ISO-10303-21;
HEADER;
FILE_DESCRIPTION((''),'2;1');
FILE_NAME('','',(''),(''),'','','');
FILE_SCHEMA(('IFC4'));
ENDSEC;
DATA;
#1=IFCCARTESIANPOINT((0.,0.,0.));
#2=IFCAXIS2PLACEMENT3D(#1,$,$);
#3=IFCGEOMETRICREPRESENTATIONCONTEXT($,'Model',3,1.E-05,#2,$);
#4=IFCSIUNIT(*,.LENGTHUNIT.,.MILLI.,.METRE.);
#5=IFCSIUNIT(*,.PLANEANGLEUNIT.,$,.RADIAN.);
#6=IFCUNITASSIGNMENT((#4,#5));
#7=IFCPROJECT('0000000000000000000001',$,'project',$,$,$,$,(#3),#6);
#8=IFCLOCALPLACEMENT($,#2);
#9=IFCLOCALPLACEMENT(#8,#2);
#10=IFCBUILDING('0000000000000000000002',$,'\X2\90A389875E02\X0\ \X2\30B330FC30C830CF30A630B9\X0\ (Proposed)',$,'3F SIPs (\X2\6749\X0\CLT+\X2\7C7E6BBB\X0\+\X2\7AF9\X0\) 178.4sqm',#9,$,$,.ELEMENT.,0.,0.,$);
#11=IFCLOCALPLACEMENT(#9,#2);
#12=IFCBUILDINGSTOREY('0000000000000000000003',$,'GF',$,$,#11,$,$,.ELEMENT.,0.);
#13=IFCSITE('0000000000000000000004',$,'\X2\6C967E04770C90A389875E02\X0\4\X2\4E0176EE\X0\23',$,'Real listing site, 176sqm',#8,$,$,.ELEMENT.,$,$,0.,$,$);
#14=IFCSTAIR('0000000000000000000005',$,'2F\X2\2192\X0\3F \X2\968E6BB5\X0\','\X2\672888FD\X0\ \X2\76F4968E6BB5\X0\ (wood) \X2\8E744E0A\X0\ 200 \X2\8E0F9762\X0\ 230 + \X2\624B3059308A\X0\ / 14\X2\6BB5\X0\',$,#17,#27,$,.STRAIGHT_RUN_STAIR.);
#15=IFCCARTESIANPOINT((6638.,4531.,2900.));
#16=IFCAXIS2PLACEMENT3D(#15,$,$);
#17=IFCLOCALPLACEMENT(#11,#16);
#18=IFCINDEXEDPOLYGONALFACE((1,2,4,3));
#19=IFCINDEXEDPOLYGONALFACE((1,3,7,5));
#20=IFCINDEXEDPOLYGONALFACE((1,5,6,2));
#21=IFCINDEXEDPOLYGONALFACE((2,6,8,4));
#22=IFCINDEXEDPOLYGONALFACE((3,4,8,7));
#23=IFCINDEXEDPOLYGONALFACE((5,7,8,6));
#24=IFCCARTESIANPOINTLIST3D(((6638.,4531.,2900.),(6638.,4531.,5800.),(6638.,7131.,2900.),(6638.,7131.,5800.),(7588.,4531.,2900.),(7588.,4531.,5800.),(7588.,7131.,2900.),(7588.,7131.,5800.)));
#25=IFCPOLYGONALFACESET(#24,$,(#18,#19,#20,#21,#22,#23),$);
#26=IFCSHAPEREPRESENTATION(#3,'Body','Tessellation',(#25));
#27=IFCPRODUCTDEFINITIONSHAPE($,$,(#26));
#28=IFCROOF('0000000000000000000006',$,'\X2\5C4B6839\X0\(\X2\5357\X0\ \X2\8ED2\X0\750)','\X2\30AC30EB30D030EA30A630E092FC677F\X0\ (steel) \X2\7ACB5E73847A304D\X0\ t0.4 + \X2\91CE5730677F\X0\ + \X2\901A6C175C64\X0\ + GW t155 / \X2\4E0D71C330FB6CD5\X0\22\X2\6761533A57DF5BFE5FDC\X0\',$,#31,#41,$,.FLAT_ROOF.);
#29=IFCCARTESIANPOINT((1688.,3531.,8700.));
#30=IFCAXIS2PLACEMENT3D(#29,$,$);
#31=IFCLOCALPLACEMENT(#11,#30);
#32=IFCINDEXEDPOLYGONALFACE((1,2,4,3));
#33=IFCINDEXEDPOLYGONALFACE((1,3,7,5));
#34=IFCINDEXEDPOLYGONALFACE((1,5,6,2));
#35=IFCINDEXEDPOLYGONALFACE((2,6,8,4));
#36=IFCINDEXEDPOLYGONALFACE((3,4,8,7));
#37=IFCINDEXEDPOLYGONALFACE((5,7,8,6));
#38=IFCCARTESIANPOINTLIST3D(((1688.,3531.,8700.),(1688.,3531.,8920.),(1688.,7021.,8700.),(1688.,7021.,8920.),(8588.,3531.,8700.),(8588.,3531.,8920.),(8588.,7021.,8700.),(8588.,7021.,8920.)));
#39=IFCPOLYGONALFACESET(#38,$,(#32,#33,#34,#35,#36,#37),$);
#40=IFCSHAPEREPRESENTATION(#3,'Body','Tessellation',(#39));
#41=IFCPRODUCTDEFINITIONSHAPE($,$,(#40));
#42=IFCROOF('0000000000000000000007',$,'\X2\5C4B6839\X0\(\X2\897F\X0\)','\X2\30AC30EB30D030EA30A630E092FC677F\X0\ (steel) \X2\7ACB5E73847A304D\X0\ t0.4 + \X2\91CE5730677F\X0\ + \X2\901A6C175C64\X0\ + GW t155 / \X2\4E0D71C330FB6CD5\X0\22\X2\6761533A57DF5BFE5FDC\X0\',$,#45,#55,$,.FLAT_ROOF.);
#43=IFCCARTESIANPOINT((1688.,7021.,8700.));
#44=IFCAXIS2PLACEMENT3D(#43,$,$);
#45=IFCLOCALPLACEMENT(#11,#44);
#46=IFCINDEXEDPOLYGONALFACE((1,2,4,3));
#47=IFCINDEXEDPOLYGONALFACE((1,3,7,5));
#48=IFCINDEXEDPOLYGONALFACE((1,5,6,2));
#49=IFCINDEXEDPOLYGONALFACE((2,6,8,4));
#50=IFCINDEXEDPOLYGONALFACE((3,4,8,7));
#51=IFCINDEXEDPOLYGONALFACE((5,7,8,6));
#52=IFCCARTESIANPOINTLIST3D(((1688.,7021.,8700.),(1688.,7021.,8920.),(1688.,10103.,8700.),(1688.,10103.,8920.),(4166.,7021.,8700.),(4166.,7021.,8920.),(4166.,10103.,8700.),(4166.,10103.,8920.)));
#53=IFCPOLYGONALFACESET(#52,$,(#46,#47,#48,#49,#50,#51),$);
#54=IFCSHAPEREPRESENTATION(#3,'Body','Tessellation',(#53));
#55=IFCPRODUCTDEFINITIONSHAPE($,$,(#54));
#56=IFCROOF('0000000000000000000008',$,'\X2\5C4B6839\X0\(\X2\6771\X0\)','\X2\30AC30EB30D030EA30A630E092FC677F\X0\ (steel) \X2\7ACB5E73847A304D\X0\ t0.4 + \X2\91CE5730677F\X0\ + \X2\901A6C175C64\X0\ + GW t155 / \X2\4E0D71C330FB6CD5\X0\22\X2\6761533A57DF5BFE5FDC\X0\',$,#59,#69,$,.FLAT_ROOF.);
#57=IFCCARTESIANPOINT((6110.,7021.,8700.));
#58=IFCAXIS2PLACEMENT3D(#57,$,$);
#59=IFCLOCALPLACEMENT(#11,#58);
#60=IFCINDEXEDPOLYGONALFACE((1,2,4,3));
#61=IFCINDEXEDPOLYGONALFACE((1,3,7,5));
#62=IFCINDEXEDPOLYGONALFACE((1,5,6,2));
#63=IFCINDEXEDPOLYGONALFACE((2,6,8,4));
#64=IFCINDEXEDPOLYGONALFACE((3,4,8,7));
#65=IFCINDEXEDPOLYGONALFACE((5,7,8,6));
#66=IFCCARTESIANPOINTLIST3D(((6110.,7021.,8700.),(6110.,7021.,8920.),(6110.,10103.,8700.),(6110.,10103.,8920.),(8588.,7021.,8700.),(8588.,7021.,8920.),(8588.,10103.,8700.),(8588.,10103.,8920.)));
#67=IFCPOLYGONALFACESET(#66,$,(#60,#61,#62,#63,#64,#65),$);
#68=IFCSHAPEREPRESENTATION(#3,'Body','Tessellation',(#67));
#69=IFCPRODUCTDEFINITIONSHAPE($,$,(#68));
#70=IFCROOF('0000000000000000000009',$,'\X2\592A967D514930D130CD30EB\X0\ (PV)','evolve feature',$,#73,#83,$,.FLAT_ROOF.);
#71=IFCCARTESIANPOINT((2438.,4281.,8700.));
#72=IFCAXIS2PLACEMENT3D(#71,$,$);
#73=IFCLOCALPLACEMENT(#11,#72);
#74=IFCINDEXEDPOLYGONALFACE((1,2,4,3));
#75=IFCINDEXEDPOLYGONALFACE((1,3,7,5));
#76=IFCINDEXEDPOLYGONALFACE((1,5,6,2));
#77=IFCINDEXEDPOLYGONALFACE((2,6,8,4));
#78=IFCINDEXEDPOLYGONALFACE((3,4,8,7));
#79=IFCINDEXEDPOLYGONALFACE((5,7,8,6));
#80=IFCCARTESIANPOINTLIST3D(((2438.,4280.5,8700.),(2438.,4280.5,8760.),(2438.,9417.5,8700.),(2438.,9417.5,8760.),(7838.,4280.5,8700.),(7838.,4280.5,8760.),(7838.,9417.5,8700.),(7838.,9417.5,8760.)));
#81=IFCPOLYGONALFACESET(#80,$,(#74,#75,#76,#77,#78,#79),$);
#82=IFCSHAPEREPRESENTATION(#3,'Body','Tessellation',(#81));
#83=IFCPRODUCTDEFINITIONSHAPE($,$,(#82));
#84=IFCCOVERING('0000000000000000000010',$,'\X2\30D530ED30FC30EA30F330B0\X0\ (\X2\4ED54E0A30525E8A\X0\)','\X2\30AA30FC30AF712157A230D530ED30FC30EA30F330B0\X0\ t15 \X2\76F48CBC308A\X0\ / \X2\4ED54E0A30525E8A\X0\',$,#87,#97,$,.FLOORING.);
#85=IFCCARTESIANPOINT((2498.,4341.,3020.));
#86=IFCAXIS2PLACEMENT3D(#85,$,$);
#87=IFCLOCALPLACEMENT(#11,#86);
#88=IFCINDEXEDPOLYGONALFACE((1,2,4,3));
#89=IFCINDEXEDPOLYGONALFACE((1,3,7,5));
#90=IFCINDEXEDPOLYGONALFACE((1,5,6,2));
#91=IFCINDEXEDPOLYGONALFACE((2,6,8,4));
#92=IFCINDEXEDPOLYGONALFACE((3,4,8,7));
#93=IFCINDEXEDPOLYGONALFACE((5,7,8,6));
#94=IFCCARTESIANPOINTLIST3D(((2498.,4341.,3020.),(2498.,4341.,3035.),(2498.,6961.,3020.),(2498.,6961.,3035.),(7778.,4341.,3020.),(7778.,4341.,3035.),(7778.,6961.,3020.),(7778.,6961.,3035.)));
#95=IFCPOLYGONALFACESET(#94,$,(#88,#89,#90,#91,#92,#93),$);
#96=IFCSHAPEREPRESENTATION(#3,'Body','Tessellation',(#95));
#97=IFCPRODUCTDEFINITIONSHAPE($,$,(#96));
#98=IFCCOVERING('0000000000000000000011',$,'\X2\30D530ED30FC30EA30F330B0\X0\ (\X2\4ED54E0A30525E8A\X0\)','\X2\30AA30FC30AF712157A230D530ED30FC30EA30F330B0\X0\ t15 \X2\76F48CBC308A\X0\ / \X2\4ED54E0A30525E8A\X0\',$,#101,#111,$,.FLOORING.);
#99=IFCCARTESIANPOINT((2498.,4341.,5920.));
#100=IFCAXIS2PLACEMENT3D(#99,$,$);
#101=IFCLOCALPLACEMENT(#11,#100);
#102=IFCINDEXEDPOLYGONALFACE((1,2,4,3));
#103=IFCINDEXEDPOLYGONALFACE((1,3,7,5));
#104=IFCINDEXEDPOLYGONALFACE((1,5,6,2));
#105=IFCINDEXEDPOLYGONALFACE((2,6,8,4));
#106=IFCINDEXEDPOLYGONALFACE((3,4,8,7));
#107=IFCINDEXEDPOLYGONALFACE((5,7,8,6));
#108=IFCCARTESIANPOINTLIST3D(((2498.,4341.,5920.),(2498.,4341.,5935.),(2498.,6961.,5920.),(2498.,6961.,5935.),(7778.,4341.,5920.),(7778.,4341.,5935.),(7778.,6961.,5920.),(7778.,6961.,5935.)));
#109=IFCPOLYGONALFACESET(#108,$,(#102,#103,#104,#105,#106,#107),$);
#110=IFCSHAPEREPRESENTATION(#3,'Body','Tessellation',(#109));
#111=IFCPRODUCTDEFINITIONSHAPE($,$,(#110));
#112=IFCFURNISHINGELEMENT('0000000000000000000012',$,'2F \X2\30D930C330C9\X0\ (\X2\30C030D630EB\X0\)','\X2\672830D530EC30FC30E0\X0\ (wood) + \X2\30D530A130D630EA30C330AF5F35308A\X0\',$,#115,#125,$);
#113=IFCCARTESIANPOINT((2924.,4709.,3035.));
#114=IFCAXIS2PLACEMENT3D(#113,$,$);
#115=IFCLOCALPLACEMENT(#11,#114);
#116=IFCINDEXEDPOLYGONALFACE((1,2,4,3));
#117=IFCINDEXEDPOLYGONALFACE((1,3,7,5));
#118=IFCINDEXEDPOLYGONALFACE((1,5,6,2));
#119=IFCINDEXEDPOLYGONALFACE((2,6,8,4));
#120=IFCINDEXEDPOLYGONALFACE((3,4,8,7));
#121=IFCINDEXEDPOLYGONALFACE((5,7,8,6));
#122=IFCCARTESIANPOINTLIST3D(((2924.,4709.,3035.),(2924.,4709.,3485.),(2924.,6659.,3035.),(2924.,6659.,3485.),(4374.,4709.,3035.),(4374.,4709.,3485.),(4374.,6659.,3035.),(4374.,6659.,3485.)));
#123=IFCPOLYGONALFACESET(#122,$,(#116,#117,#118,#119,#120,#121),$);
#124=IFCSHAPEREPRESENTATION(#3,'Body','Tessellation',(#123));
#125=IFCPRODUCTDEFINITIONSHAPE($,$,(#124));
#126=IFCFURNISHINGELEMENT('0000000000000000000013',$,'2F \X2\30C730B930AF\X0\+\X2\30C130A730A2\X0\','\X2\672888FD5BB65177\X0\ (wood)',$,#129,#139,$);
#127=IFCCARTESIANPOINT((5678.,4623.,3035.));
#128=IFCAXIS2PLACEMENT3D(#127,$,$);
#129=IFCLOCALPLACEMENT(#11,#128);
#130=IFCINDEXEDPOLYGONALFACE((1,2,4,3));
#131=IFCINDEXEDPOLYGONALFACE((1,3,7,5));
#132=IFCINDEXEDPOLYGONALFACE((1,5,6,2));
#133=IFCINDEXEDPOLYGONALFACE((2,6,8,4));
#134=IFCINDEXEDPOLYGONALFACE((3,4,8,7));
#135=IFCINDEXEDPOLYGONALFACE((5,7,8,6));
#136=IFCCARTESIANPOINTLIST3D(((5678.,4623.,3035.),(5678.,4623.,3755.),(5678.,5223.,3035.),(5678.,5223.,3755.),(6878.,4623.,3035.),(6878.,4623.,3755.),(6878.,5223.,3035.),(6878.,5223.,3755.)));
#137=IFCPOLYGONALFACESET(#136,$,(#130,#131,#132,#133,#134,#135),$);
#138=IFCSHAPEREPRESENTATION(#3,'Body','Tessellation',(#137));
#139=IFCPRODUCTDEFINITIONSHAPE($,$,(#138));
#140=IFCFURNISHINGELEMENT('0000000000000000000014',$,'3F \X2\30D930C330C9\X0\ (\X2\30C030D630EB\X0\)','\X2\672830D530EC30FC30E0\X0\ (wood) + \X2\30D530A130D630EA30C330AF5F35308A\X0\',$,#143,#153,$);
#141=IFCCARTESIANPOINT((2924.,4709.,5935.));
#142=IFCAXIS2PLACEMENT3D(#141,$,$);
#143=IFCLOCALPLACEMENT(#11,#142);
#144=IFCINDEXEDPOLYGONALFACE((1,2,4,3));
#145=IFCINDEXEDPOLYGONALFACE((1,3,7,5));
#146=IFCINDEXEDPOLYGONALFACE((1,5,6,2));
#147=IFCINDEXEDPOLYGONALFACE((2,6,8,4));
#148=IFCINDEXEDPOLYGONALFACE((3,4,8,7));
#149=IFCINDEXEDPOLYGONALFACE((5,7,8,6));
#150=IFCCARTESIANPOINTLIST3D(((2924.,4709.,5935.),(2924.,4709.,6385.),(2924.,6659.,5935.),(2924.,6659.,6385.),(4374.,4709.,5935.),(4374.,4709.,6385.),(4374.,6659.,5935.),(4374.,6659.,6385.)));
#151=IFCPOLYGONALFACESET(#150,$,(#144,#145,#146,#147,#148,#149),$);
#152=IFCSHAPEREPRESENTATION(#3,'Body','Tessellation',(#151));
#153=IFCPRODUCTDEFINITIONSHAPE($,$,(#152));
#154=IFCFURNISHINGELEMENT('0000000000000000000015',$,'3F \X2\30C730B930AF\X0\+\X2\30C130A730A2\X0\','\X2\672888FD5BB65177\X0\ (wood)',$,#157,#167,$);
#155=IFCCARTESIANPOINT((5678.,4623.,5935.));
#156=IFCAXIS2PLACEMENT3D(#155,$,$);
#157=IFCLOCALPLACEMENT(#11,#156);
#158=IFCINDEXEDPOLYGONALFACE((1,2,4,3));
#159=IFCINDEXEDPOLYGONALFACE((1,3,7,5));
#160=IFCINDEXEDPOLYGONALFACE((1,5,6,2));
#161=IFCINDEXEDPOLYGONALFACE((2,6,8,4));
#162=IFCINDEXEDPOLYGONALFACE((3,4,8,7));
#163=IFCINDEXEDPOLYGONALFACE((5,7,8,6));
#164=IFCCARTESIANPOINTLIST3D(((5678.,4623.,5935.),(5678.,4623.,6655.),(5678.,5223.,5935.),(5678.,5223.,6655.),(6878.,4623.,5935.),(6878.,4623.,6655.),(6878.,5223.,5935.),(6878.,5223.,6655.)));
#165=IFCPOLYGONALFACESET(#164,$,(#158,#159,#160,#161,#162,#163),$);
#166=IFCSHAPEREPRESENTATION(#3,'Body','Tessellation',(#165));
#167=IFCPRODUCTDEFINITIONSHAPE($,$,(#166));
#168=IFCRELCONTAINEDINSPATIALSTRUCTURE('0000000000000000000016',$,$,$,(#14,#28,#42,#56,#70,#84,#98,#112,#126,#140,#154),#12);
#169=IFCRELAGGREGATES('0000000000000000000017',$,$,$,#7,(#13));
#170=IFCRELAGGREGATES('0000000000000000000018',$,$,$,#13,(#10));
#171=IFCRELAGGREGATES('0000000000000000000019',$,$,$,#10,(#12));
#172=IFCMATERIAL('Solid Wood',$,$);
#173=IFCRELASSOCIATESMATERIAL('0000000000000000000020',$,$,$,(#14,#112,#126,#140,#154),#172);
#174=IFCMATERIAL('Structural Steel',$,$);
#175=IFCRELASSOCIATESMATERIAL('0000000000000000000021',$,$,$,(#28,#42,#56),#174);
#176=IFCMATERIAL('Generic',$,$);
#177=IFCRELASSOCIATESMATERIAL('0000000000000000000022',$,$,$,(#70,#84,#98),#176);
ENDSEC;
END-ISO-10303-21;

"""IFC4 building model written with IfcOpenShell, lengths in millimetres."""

from ifc_helpers import new_model, si_unit, frame, frame_2d, origin, place, context, project, spatial, rectangle, extrude, material, element, save


model = new_model("IFC4")

# Units and contexts
model_context = context("Model", 3, precision=1e-05, world=origin())
ifc_project = project(units=[si_unit("LENGTHUNIT", "METRE", prefix="MILLI"), si_unit("PLANEANGLEUNIT", "RADIAN")], contexts=[model_context])

# Site, building, storey
site_placement = place(None, origin())
site = spatial("IfcSite", under=ifc_project, at=site_placement, Name="沖縄県那覇市4丁目23", ObjectType="Real listing site, 176sqm", CompositionType="ELEMENT", RefElevation=0.0)
building_placement = place(site_placement, origin())
building = spatial("IfcBuilding", under=site, at=building_placement, Name="那覇市 コートハウス (Proposed)", ObjectType="3F SIPs (杉CLT+籾殻+竹) 178.4sqm", CompositionType="ELEMENT", ElevationOfRefHeight=0.0, ElevationOfTerrain=0.0)
storey_placement = place(building_placement, origin())
storey = spatial("IfcBuildingStorey", under=building, at=storey_placement, Name="GF", CompositionType="ELEMENT", Elevation=0.0)

# Shared definitions
ifc_material_1 = material(Name="Solid Wood")

# Stair
stair_placement = place(storey_placement, frame((6638.0, 4531.0, 2900.0)))
element("IfcStair", 1, at=stair_placement, inside=storey, material=ifc_material_1, Name="2F→3F 階段", Description="木製 直階段 (wood) 蹴上 200 踏面 230 + 手すり / 14段", PredefinedType="STRAIGHT_RUN_STAIR", context=model_context, shape_type="SweptSolid", body=[
    extrude(rectangle(XDim=950.0, YDim=2600.0, at=frame_2d((475.0, 1300.0))), frame((6638.0, 4531.0, 2900.0)), (0.0, 0.0, 1.0), 2900.0),
])

# Roofs
ifc_material_2 = material(Name="Structural Steel")
roof_1_placement = place(storey_placement, frame((1688.0, 3531.0, 8700.0)))
element("IfcRoof", 2, at=roof_1_placement, inside=storey, material=ifc_material_2, Name="屋根(南 軒750)", Description="ガルバリウム鋼板 (steel) 立平葺き t0.4 + 野地板 + 通気層 + GW t155 / 不燃・法22条区域対応", PredefinedType="FLAT_ROOF", context=model_context, shape_type="SweptSolid", body=[
    extrude(rectangle(XDim=6900.0, YDim=3490.0, at=frame_2d((3450.0, 1745.0))), frame((1688.0, 3531.0, 8700.0)), (0.0, 0.0, 1.0), 220.0),
])
roof_2_placement = place(storey_placement, frame((1688.0, 7021.0, 8700.0)))
element("IfcRoof", 3, at=roof_2_placement, inside=storey, material=ifc_material_2, Name="屋根(西)", Description="ガルバリウム鋼板 (steel) 立平葺き t0.4 + 野地板 + 通気層 + GW t155 / 不燃・法22条区域対応", PredefinedType="FLAT_ROOF", context=model_context, shape_type="SweptSolid", body=[
    extrude(rectangle(XDim=2478.0, YDim=3082.0, at=frame_2d((1239.0, 1541.0))), frame((1688.0, 7021.0, 8700.0)), (0.0, 0.0, 1.0), 220.0),
])
roof_3_placement = place(storey_placement, frame((6110.0, 7021.0, 8700.0)))
element("IfcRoof", 4, at=roof_3_placement, inside=storey, material=ifc_material_2, Name="屋根(東)", Description="ガルバリウム鋼板 (steel) 立平葺き t0.4 + 野地板 + 通気層 + GW t155 / 不燃・法22条区域対応", PredefinedType="FLAT_ROOF", context=model_context, shape_type="SweptSolid", body=[
    extrude(rectangle(XDim=2478.0, YDim=3082.0, at=frame_2d((1239.0, 1541.0))), frame((6110.0, 7021.0, 8700.0)), (0.0, 0.0, 1.0), 220.0),
])
ifc_material_3 = material(Name="Generic")
roof_4_placement = place(storey_placement, frame((2438.0, 4281.0, 8700.0)))
element("IfcRoof", 5, at=roof_4_placement, inside=storey, material=ifc_material_3, Name="太陽光パネル (PV)", Description="evolve feature", PredefinedType="FLAT_ROOF", context=model_context, shape_type="SweptSolid", body=[
    extrude(rectangle(XDim=5400.0, YDim=5137.0, at=frame_2d((2700.0, 2568.0))), frame((2438.0, 4281.0, 8700.0)), (0.0, 0.0, 1.0), 60.0),
])

# Coverings
covering_1_placement = place(storey_placement, frame((2498.0, 4341.0, 3020.0)))
element("IfcCovering", 6, at=covering_1_placement, inside=storey, material=ifc_material_3, Name="フローリング (仕上げ床)", Description="オーク無垢フローリング t15 直貼り / 仕上げ床", PredefinedType="FLOORING", context=model_context, shape_type="SweptSolid", body=[
    extrude(rectangle(XDim=5280.0, YDim=2620.0, at=frame_2d((2640.0, 1310.0))), frame((2498.0, 4341.0, 3020.0)), (0.0, 0.0, 1.0), 15.0),
])
covering_2_placement = place(storey_placement, frame((2498.0, 4341.0, 5920.0)))
element("IfcCovering", 7, at=covering_2_placement, inside=storey, material=ifc_material_3, Name="フローリング (仕上げ床)", Description="オーク無垢フローリング t15 直貼り / 仕上げ床", PredefinedType="FLOORING", context=model_context, shape_type="SweptSolid", body=[
    extrude(rectangle(XDim=5280.0, YDim=2620.0, at=frame_2d((2640.0, 1310.0))), frame((2498.0, 4341.0, 5920.0)), (0.0, 0.0, 1.0), 15.0),
])

# Furnishing elements
furnishing_1_placement = place(storey_placement, frame((2924.0, 4709.0, 3035.0)))
element("IfcFurnishingElement", 8, at=furnishing_1_placement, inside=storey, material=ifc_material_1, Name="2F ベッド (ダブル)", Description="木フレーム (wood) + ファブリック張り", context=model_context, shape_type="SweptSolid", body=[
    extrude(rectangle(XDim=1450.0, YDim=1950.0, at=frame_2d((725.0, 975.0))), frame((2924.0, 4709.0, 3035.0)), (0.0, 0.0, 1.0), 450.0),
])
furnishing_2_placement = place(storey_placement, frame((5678.0, 4623.0, 3035.0)))
element("IfcFurnishingElement", 9, at=furnishing_2_placement, inside=storey, material=ifc_material_1, Name="2F デスク+チェア", Description="木製家具 (wood)", context=model_context, shape_type="SweptSolid", body=[
    extrude(rectangle(XDim=1200.0, YDim=600.0, at=frame_2d((600.0, 300.0))), frame((5678.0, 4623.0, 3035.0)), (0.0, 0.0, 1.0), 720.0),
])
furnishing_3_placement = place(storey_placement, frame((2924.0, 4709.0, 5935.0)))
element("IfcFurnishingElement", 10, at=furnishing_3_placement, inside=storey, material=ifc_material_1, Name="3F ベッド (ダブル)", Description="木フレーム (wood) + ファブリック張り", context=model_context, shape_type="SweptSolid", body=[
    extrude(rectangle(XDim=1450.0, YDim=1950.0, at=frame_2d((725.0, 975.0))), frame((2924.0, 4709.0, 5935.0)), (0.0, 0.0, 1.0), 450.0),
])
furnishing_4_placement = place(storey_placement, frame((5678.0, 4623.0, 5935.0)))
element("IfcFurnishingElement", 11, at=furnishing_4_placement, inside=storey, material=ifc_material_1, Name="3F デスク+チェア", Description="木製家具 (wood)", context=model_context, shape_type="SweptSolid", body=[
    extrude(rectangle(XDim=1200.0, YDim=600.0, at=frame_2d((600.0, 300.0))), frame((5678.0, 4623.0, 5935.0)), (0.0, 0.0, 1.0), 720.0),
])

save(model, "model.ifc")
